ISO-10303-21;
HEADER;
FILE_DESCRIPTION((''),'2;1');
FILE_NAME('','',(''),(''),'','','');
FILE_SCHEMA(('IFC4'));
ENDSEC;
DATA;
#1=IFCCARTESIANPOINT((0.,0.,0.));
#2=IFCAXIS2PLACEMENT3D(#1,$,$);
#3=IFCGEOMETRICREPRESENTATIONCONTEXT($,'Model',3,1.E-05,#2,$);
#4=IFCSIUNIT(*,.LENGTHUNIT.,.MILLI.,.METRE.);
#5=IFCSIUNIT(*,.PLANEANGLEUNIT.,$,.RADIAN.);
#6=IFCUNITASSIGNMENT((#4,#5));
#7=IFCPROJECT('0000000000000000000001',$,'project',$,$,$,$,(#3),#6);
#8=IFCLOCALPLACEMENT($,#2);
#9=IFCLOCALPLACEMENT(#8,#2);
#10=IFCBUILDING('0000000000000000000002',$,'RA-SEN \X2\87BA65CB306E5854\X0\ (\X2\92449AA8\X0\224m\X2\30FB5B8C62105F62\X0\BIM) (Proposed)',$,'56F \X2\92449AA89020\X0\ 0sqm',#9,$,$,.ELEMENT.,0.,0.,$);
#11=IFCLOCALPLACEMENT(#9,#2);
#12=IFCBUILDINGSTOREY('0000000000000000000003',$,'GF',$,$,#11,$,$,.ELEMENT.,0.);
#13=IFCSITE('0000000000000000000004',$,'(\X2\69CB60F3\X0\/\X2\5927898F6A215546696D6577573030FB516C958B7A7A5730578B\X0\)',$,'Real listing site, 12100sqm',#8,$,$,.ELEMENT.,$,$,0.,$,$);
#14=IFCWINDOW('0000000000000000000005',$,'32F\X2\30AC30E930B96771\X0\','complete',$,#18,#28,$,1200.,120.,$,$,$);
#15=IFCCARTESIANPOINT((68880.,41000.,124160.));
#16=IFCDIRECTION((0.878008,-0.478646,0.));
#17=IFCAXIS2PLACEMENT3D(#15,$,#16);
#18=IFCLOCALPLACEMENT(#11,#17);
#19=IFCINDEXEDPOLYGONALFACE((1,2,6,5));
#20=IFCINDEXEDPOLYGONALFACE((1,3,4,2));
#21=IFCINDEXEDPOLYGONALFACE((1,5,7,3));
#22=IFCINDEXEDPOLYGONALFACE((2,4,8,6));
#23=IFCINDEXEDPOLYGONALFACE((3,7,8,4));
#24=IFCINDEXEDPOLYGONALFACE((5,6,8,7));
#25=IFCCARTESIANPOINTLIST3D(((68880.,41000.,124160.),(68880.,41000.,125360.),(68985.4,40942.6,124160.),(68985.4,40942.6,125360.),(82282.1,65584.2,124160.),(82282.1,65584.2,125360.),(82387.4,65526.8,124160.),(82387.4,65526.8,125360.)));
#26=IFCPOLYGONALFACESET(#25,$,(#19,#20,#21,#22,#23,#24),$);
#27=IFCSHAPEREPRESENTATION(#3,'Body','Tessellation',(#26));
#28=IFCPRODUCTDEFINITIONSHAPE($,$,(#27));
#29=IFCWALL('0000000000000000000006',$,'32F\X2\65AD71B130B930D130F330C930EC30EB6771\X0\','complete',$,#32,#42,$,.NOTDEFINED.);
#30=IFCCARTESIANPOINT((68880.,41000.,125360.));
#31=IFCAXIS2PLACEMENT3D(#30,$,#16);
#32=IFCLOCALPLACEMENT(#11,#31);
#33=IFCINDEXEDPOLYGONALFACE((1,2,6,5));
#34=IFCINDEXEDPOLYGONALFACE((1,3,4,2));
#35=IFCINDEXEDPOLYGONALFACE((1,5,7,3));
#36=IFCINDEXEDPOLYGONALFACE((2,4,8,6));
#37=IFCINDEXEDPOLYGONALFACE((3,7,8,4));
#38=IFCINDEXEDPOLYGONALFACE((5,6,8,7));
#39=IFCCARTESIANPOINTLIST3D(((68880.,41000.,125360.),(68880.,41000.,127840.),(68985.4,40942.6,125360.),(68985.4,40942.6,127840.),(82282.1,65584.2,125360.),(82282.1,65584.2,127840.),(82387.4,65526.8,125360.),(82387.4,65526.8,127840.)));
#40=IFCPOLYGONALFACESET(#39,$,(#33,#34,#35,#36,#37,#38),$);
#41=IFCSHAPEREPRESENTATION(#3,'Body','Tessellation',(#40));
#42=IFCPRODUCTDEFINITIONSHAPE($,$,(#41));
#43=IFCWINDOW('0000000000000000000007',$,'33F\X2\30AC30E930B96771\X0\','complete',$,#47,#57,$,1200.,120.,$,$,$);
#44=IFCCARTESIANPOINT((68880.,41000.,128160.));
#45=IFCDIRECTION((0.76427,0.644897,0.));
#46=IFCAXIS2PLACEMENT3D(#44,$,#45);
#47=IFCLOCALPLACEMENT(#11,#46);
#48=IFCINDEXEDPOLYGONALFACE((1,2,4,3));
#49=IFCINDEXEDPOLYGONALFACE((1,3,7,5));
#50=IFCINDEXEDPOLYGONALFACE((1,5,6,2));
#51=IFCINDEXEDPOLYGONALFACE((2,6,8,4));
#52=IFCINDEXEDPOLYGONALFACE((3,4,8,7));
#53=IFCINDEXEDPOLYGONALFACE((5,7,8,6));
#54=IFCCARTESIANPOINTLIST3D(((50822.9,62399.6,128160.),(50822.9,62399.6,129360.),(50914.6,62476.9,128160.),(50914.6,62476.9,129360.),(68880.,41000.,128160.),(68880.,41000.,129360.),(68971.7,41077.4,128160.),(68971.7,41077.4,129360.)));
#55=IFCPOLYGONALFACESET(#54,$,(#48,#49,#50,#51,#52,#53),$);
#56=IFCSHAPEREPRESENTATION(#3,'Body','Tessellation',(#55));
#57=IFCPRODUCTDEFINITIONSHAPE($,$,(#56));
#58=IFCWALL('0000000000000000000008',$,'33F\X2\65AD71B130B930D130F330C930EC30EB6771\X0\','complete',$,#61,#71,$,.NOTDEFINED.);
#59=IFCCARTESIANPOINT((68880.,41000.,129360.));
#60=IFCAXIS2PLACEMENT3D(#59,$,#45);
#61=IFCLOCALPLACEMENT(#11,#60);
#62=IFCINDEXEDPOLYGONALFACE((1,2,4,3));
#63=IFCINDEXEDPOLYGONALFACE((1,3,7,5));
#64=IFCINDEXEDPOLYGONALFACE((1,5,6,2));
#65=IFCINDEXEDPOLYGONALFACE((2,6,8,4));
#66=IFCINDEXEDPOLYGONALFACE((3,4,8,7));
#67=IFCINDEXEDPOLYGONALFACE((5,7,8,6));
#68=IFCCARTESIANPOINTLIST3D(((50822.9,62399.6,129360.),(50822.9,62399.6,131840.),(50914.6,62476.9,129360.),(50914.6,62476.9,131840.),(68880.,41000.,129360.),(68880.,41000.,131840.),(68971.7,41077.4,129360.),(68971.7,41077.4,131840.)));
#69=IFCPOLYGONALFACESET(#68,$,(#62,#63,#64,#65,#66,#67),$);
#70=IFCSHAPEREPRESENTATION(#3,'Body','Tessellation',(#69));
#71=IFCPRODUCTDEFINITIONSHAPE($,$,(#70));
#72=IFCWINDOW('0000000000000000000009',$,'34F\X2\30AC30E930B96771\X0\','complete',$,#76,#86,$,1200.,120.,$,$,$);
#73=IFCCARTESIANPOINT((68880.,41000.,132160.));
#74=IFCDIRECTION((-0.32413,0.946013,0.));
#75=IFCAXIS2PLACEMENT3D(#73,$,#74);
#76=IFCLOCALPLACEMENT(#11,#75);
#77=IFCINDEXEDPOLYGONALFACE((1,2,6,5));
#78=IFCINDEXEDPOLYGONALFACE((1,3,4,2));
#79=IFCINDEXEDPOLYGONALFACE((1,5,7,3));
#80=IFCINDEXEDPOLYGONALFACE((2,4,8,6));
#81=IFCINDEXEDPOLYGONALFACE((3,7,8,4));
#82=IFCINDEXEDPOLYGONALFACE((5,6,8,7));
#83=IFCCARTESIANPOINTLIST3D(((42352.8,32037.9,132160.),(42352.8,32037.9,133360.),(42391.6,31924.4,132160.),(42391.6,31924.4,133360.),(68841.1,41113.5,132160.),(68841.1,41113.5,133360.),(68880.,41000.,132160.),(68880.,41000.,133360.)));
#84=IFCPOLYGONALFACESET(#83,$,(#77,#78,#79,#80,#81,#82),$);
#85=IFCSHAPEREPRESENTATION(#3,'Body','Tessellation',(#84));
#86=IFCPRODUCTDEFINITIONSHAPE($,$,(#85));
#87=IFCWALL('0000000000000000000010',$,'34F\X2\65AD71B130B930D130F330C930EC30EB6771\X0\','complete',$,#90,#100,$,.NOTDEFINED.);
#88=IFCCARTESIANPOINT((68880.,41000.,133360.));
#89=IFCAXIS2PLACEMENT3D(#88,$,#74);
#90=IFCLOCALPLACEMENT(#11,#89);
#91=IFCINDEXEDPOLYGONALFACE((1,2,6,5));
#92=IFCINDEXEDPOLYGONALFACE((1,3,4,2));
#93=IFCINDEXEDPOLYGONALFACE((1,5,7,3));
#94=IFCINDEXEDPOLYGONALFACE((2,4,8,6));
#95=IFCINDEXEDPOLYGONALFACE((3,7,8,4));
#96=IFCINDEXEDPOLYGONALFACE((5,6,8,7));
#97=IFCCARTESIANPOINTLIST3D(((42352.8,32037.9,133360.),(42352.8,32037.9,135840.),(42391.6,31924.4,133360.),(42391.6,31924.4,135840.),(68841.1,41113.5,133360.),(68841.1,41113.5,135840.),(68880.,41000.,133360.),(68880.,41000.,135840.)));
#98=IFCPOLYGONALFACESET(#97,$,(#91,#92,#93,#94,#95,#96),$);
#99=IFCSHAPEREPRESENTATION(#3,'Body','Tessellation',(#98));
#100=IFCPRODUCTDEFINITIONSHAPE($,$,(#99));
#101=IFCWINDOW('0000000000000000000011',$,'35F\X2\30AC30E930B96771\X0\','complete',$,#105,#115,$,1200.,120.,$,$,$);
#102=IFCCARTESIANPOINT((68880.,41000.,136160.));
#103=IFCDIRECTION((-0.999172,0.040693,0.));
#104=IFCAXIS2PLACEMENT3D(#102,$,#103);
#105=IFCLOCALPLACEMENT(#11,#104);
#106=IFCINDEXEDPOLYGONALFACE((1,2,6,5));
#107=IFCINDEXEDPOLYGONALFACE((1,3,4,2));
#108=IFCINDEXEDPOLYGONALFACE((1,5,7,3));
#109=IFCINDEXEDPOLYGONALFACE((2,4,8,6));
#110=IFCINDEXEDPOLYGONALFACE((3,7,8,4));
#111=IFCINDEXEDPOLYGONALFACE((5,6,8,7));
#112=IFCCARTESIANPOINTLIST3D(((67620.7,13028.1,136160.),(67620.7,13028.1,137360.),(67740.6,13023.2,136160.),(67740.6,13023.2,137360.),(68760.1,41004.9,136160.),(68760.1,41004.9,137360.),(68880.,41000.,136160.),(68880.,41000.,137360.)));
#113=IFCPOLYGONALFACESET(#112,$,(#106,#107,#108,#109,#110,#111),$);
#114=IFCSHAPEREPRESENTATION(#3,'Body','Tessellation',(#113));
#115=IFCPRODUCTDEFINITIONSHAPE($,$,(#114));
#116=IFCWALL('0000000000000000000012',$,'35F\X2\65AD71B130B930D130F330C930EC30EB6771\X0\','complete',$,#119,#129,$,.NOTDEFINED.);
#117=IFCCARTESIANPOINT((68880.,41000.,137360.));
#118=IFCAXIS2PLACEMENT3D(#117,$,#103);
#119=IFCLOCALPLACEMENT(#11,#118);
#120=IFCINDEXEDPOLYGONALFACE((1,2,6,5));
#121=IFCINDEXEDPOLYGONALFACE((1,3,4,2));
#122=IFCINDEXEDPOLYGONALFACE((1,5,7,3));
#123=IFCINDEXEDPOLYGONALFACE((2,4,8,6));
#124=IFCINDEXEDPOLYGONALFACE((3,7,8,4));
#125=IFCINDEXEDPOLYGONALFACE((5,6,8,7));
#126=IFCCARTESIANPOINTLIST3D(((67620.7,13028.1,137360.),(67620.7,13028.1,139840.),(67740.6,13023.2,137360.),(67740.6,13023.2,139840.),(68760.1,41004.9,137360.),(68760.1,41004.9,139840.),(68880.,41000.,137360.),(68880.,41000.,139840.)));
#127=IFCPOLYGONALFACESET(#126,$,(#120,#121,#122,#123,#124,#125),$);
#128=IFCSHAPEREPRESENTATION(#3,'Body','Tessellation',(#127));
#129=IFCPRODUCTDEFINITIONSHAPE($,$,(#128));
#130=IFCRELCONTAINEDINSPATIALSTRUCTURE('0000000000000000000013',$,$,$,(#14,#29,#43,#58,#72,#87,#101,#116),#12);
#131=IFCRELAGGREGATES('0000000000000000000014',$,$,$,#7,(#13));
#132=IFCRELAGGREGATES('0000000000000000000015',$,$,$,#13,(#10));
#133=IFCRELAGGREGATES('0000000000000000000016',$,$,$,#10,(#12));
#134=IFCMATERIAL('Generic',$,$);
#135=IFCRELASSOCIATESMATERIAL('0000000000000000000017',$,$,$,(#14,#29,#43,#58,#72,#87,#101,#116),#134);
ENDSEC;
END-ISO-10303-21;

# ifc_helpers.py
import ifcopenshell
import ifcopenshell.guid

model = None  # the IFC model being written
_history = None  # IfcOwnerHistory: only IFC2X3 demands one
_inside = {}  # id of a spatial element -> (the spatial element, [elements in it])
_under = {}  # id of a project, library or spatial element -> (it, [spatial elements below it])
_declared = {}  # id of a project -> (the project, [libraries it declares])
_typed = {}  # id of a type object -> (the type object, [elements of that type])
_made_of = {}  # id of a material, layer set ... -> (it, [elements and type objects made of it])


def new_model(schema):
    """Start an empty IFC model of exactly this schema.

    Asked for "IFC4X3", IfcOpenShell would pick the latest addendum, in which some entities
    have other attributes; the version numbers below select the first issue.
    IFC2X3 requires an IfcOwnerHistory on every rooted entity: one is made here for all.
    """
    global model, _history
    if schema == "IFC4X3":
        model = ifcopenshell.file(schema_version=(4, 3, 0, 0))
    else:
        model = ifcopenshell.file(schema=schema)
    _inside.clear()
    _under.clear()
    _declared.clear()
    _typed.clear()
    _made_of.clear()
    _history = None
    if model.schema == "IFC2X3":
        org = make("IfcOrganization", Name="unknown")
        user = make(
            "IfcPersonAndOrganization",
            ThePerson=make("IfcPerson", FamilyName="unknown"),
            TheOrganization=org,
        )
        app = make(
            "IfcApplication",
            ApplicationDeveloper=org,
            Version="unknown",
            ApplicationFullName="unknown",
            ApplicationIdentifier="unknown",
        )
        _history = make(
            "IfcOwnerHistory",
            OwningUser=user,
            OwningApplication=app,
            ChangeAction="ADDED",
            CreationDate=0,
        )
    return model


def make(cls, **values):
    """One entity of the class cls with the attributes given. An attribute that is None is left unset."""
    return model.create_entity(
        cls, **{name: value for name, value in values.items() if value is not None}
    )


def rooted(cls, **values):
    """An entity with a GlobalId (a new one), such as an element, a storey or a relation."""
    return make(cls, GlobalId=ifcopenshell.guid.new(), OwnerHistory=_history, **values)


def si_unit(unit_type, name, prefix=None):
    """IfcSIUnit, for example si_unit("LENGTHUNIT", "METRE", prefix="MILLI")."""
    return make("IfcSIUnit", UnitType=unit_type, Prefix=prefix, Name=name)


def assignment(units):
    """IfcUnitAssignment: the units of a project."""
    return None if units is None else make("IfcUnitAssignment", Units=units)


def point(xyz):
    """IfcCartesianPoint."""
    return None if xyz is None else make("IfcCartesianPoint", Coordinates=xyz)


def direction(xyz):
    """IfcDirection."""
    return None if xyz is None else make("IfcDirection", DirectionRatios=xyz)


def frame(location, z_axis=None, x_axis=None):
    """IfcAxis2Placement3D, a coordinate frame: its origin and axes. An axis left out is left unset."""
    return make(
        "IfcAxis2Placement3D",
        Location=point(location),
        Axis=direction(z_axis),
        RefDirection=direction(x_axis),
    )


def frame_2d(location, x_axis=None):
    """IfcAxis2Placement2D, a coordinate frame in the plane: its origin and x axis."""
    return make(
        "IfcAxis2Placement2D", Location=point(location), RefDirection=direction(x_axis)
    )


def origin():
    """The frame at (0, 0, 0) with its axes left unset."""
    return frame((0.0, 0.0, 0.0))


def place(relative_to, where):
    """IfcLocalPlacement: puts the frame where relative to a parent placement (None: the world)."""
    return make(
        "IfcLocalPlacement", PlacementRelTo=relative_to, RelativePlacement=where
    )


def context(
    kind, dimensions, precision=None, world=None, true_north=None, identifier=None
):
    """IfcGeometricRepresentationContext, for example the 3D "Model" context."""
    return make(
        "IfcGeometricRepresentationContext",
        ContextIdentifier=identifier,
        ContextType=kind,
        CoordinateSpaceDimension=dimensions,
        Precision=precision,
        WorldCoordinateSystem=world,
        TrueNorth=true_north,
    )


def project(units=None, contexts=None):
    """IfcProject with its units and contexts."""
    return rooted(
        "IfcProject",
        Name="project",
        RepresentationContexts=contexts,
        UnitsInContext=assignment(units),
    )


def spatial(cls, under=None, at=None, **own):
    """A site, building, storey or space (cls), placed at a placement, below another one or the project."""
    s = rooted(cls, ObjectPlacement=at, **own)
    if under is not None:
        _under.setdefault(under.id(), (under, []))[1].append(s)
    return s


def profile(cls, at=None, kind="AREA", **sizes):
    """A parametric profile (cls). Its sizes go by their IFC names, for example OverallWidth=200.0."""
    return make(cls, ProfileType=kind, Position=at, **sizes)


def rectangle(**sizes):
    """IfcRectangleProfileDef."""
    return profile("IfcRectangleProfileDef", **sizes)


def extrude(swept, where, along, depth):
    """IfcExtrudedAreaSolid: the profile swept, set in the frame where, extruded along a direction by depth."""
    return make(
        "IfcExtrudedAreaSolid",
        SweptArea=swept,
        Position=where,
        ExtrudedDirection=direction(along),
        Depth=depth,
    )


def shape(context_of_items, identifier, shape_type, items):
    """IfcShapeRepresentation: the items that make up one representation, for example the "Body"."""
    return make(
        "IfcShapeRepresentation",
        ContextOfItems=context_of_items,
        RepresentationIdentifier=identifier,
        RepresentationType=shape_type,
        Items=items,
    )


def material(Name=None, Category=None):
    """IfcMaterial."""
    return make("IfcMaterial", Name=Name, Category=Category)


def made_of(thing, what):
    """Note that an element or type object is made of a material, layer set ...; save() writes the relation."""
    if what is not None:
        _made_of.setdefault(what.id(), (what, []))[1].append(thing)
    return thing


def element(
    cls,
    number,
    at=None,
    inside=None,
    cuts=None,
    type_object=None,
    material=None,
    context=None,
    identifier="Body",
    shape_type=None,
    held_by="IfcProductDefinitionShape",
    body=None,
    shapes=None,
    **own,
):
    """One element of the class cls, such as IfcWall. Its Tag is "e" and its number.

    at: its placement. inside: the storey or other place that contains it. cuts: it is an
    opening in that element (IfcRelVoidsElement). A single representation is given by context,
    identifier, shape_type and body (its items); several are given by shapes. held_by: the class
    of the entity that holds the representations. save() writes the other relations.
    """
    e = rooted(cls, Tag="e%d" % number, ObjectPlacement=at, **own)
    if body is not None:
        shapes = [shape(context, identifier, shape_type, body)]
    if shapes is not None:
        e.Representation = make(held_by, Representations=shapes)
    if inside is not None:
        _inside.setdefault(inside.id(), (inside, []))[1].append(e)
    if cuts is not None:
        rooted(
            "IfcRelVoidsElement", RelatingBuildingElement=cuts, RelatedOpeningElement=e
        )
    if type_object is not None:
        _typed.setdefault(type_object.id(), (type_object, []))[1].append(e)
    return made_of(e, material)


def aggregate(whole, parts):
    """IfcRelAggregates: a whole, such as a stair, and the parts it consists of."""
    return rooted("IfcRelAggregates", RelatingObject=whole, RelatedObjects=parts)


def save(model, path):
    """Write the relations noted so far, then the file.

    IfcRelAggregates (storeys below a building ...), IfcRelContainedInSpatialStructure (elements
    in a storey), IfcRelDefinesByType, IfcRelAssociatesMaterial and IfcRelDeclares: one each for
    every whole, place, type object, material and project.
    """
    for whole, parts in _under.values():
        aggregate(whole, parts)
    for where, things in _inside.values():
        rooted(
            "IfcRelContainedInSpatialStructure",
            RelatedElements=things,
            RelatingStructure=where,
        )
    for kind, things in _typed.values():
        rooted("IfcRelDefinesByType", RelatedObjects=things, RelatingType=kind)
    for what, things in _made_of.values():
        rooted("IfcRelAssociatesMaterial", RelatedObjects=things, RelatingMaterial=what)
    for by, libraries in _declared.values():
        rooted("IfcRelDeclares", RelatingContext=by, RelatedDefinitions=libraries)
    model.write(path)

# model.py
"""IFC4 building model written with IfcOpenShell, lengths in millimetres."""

from ifc_helpers import new_model, si_unit, frame, frame_2d, origin, place, context, project, spatial, rectangle, extrude, material, element, save


model = new_model("IFC4")

# Units and contexts
model_context = context("Model", 3, precision=1e-05, world=origin())
ifc_project = project(units=[si_unit("LENGTHUNIT", "METRE", prefix="MILLI"), si_unit("PLANEANGLEUNIT", "RADIAN")], contexts=[model_context])

# Site, building, storey
site_placement = place(None, origin())
site = spatial("IfcSite", under=ifc_project, at=site_placement, Name="(構想/大規模商業敷地・公開空地型)", ObjectType="Real listing site, 12100sqm", CompositionType="ELEMENT", RefElevation=0.0)
building_placement = place(site_placement, origin())
building = spatial("IfcBuilding", under=site, at=building_placement, Name="RA-SEN 螺旋の塔 (鉄骨224m・完成形BIM) (Proposed)", ObjectType="56F 鉄骨造 0sqm", CompositionType="ELEMENT", ElevationOfRefHeight=0.0, ElevationOfTerrain=0.0)
storey_placement = place(building_placement, origin())
storey = spatial("IfcBuildingStorey", under=building, at=storey_placement, Name="GF", CompositionType="ELEMENT", Elevation=0.0)

# Shared definitions
ifc_material = material(Name="Generic")

# Window
window_1_placement = place(storey_placement, frame((68880.0, 41000.0, 124160.0), x_axis=(0.878008, -0.478646, 0.0)))
element("IfcWindow", 1, at=window_1_placement, inside=storey, material=ifc_material, Name="32Fガラス東", Description="complete", OverallHeight=1200.0, OverallWidth=120.0, context=model_context, shape_type="SweptSolid", body=[
    extrude(rectangle(XDim=120.0, YDim=28000.0, at=frame_2d((60.0, 14000.0))), frame((68880.0, 41000.0, 124160.0), x_axis=(0.878008, -0.478646, 0.0)), (0.0, 0.0, 1.0), 1200.0),
])

# Wall
wall_1_placement = place(storey_placement, frame((68880.0, 41000.0, 125360.0), x_axis=(0.878008, -0.478646, 0.0)))
element("IfcWall", 2, at=wall_1_placement, inside=storey, material=ifc_material, Name="32F断熱スパンドレル東", Description="complete", PredefinedType="NOTDEFINED", context=model_context, shape_type="SweptSolid", body=[
    extrude(rectangle(XDim=120.0, YDim=28000.0, at=frame_2d((60.0, 14000.0))), frame((68880.0, 41000.0, 125360.0), x_axis=(0.878008, -0.478646, 0.0)), (0.0, 0.0, 1.0), 2480.0),
])

# Window
window_2_placement = place(storey_placement, frame((68880.0, 41000.0, 128160.0), x_axis=(0.76427, 0.644897, 0.0)))
element("IfcWindow", 3, at=window_2_placement, inside=storey, material=ifc_material, Name="33Fガラス東", Description="complete", OverallHeight=1200.0, OverallWidth=120.0, context=model_context, shape_type="SweptSolid", body=[
    extrude(rectangle(XDim=120.0, YDim=28000.0, at=frame_2d((60.0, 14000.0))), frame((68880.0, 41000.0, 128160.0), x_axis=(0.76427, 0.644897, 0.0)), (0.0, 0.0, 1.0), 1200.0),
])

# Wall
wall_2_placement = place(storey_placement, frame((68880.0, 41000.0, 129360.0), x_axis=(0.76427, 0.644897, 0.0)))
element("IfcWall", 4, at=wall_2_placement, inside=storey, material=ifc_material, Name="33F断熱スパンドレル東", Description="complete", PredefinedType="NOTDEFINED", context=model_context, shape_type="SweptSolid", body=[
    extrude(rectangle(XDim=120.0, YDim=28000.0, at=frame_2d((60.0, 14000.0))), frame((68880.0, 41000.0, 129360.0), x_axis=(0.76427, 0.644897, 0.0)), (0.0, 0.0, 1.0), 2480.0),
])

# Window
window_3_placement = place(storey_placement, frame((68880.0, 41000.0, 132160.0), x_axis=(-0.32413, 0.946013, 0.0)))
element("IfcWindow", 5, at=window_3_placement, inside=storey, material=ifc_material, Name="34Fガラス東", Description="complete", OverallHeight=1200.0, OverallWidth=120.0, context=model_context, shape_type="SweptSolid", body=[
    extrude(rectangle(XDim=120.0, YDim=28000.0, at=frame_2d((60.0, 14000.0))), frame((68880.0, 41000.0, 132160.0), x_axis=(-0.32413, 0.946013, 0.0)), (0.0, 0.0, 1.0), 1200.0),
])

# Wall
wall_3_placement = place(storey_placement, frame((68880.0, 41000.0, 133360.0), x_axis=(-0.32413, 0.946013, 0.0)))
element("IfcWall", 6, at=wall_3_placement, inside=storey, material=ifc_material, Name="34F断熱スパンドレル東", Description="complete", PredefinedType="NOTDEFINED", context=model_context, shape_type="SweptSolid", body=[
    extrude(rectangle(XDim=120.0, YDim=28000.0, at=frame_2d((60.0, 14000.0))), frame((68880.0, 41000.0, 133360.0), x_axis=(-0.32413, 0.946013, 0.0)), (0.0, 0.0, 1.0), 2480.0),
])

# Window
window_4_placement = place(storey_placement, frame((68880.0, 41000.0, 136160.0), x_axis=(-0.999172, 0.040693, 0.0)))
element("IfcWindow", 7, at=window_4_placement, inside=storey, material=ifc_material, Name="35Fガラス東", Description="complete", OverallHeight=1200.0, OverallWidth=120.0, context=model_context, shape_type="SweptSolid", body=[
    extrude(rectangle(XDim=120.0, YDim=28000.0, at=frame_2d((60.0, 14000.0))), frame((68880.0, 41000.0, 136160.0), x_axis=(-0.999172, 0.040693, 0.0)), (0.0, 0.0, 1.0), 1200.0),
])

# Wall
wall_4_placement = place(storey_placement, frame((68880.0, 41000.0, 137360.0), x_axis=(-0.999172, 0.040693, 0.0)))
element("IfcWall", 8, at=wall_4_placement, inside=storey, material=ifc_material, Name="35F断熱スパンドレル東", Description="complete", PredefinedType="NOTDEFINED", context=model_context, shape_type="SweptSolid", body=[
    extrude(rectangle(XDim=120.0, YDim=28000.0, at=frame_2d((60.0, 14000.0))), frame((68880.0, 41000.0, 137360.0), x_axis=(-0.999172, 0.040693, 0.0)), (0.0, 0.0, 1.0), 2480.0),
])

save(model, "model.ifc")
